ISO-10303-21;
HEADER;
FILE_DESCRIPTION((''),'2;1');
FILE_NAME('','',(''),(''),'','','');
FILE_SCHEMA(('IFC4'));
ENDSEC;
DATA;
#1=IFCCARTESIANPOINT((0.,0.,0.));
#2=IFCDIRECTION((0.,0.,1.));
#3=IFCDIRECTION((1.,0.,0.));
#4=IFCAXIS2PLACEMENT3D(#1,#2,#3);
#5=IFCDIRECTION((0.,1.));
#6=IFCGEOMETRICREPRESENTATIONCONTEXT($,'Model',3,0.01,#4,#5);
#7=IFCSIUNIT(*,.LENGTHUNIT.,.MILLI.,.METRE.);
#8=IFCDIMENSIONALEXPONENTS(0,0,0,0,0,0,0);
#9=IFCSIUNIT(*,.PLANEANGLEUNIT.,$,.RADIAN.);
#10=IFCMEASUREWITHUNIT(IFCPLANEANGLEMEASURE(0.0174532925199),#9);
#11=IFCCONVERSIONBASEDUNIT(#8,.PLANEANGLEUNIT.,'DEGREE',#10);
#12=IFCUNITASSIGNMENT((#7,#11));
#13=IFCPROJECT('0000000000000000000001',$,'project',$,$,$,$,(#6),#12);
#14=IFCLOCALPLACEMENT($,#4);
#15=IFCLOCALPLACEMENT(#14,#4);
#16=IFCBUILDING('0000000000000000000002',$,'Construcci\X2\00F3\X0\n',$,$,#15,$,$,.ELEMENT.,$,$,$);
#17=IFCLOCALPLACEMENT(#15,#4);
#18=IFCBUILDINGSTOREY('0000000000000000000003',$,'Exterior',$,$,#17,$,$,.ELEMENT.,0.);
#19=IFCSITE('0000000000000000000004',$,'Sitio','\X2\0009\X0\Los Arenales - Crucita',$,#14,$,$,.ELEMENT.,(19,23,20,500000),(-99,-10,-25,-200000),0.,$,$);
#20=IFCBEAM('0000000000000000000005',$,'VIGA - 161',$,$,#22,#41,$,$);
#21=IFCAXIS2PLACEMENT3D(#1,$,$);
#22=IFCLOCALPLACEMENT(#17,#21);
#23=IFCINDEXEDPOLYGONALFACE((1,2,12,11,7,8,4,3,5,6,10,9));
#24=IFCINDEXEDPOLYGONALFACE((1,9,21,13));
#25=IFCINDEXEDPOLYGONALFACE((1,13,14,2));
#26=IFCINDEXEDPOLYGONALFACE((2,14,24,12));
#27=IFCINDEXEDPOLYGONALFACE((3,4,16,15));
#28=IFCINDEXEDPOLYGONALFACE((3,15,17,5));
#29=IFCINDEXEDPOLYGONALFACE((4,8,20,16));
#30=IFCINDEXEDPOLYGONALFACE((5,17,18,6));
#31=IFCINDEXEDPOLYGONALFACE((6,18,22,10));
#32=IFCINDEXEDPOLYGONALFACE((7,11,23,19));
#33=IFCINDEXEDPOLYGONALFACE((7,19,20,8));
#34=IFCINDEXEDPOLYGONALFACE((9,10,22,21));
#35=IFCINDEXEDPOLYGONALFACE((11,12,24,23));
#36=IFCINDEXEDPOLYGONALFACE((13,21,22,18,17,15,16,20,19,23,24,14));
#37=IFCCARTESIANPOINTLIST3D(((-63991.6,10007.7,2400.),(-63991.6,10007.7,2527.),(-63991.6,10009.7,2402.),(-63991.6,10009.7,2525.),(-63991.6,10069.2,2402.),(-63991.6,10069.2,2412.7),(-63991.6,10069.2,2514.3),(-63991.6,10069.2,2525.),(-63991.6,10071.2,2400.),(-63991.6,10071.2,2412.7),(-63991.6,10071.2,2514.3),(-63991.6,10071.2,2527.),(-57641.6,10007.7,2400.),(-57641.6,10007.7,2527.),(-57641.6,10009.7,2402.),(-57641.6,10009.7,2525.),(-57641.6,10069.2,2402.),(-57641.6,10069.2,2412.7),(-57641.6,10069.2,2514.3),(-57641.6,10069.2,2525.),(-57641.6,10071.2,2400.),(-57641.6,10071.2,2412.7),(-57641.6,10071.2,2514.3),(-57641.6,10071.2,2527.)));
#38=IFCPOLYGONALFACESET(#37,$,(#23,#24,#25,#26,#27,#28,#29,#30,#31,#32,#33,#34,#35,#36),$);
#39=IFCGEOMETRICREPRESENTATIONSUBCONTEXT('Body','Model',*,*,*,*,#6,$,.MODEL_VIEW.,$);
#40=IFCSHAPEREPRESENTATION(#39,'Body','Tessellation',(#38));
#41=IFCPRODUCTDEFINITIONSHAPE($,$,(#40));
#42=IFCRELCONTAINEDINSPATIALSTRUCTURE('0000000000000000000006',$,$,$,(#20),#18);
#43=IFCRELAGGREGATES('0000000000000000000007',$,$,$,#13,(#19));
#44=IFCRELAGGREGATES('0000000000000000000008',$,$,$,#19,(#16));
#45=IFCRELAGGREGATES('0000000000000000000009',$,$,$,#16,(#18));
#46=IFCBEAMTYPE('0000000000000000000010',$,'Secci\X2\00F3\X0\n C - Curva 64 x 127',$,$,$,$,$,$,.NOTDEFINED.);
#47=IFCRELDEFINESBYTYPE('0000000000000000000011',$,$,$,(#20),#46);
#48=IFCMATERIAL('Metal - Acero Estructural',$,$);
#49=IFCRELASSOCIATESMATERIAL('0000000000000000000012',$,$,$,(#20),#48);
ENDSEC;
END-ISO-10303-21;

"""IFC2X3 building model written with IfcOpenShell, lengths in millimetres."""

from ifc_helpers import new_model, entity, si_unit, converted_unit, direction, frame, origin_with_axes, place, context, subcontext, project, spatial, polyline, outline, extrude, material, type_object, element, save


model = new_model("IFC2X3")

# Units and contexts
model_context = context("Model", 3, precision=0.01, world=origin_with_axes(), true_north=direction((0.0, 1.0)))
body_context = subcontext(model_context, "Body", "Model", "MODEL_VIEW")
ifc_project = project(units=[si_unit("LENGTHUNIT", "METRE", prefix="MILLI"), converted_unit("PLANEANGLEUNIT", "DEGREE", entity("IfcPlaneAngleMeasure", 0.0174532925199), si_unit("PLANEANGLEUNIT", "RADIAN"), dimensions=[0, 0, 0, 0, 0, 0, 0])], contexts=[model_context])

# Site, building, storey
site_placement = place(None, origin_with_axes())
site = spatial("IfcSite", under=ifc_project, at=site_placement, Name="Sitio", Description="\tLos Arenales - Crucita", CompositionType="ELEMENT", RefLatitude=(19, 23, 20, 500000), RefLongitude=(-99, -10, -25, -200000), RefElevation=0.0)
building_placement = place(site_placement, origin_with_axes())
building = spatial("IfcBuilding", under=site, at=building_placement, Name="Construcción", CompositionType="ELEMENT")
storey_placement = place(building_placement, origin_with_axes())
storey = spatial("IfcBuildingStorey", under=building, at=storey_placement, Name="Exterior", CompositionType="ELEMENT", Elevation=0.0)

# Beam
ifc_material_1 = material(Name="Metal - Acero Estructural")
beam_type = type_object("IfcBeamType", Name="Sección C - Curva 64 x 127", PredefinedType="NOTDEFINED")
beam_placement = place(storey_placement, frame((-57641.6, 10039.4, 2527.0), z_axis=(0.0, 0.0, 1.0), x_axis=(0.0, 1.0, 0.0)))
element("IfcBeam", 1, at=beam_placement, inside=storey, type_object=beam_type, material=ifc_material_1, Name="VIGA - 161", context=body_context, shape_type="SweptSolid", body=[
    extrude(outline(polyline([(31.8, -127.0), (31.8, -114.3), (29.8, -114.3), (29.8, -125.0), (-29.8, -125.0), (-29.8, -2.0), (29.8, -2.0), (29.8, -12.7), (31.8, -12.7), (31.8, 0.0), (-31.8, 0.0), (-31.8, -127.0), (31.8, -127.0)])), frame((0.0, 6350.0, 0.0), z_axis=(0.0, -1.0, 0.0), x_axis=(1.0, 0.0, 0.0)), (0.0, 0.0, 1.0), 6350.0),
])

save(model, "model.ifc")
